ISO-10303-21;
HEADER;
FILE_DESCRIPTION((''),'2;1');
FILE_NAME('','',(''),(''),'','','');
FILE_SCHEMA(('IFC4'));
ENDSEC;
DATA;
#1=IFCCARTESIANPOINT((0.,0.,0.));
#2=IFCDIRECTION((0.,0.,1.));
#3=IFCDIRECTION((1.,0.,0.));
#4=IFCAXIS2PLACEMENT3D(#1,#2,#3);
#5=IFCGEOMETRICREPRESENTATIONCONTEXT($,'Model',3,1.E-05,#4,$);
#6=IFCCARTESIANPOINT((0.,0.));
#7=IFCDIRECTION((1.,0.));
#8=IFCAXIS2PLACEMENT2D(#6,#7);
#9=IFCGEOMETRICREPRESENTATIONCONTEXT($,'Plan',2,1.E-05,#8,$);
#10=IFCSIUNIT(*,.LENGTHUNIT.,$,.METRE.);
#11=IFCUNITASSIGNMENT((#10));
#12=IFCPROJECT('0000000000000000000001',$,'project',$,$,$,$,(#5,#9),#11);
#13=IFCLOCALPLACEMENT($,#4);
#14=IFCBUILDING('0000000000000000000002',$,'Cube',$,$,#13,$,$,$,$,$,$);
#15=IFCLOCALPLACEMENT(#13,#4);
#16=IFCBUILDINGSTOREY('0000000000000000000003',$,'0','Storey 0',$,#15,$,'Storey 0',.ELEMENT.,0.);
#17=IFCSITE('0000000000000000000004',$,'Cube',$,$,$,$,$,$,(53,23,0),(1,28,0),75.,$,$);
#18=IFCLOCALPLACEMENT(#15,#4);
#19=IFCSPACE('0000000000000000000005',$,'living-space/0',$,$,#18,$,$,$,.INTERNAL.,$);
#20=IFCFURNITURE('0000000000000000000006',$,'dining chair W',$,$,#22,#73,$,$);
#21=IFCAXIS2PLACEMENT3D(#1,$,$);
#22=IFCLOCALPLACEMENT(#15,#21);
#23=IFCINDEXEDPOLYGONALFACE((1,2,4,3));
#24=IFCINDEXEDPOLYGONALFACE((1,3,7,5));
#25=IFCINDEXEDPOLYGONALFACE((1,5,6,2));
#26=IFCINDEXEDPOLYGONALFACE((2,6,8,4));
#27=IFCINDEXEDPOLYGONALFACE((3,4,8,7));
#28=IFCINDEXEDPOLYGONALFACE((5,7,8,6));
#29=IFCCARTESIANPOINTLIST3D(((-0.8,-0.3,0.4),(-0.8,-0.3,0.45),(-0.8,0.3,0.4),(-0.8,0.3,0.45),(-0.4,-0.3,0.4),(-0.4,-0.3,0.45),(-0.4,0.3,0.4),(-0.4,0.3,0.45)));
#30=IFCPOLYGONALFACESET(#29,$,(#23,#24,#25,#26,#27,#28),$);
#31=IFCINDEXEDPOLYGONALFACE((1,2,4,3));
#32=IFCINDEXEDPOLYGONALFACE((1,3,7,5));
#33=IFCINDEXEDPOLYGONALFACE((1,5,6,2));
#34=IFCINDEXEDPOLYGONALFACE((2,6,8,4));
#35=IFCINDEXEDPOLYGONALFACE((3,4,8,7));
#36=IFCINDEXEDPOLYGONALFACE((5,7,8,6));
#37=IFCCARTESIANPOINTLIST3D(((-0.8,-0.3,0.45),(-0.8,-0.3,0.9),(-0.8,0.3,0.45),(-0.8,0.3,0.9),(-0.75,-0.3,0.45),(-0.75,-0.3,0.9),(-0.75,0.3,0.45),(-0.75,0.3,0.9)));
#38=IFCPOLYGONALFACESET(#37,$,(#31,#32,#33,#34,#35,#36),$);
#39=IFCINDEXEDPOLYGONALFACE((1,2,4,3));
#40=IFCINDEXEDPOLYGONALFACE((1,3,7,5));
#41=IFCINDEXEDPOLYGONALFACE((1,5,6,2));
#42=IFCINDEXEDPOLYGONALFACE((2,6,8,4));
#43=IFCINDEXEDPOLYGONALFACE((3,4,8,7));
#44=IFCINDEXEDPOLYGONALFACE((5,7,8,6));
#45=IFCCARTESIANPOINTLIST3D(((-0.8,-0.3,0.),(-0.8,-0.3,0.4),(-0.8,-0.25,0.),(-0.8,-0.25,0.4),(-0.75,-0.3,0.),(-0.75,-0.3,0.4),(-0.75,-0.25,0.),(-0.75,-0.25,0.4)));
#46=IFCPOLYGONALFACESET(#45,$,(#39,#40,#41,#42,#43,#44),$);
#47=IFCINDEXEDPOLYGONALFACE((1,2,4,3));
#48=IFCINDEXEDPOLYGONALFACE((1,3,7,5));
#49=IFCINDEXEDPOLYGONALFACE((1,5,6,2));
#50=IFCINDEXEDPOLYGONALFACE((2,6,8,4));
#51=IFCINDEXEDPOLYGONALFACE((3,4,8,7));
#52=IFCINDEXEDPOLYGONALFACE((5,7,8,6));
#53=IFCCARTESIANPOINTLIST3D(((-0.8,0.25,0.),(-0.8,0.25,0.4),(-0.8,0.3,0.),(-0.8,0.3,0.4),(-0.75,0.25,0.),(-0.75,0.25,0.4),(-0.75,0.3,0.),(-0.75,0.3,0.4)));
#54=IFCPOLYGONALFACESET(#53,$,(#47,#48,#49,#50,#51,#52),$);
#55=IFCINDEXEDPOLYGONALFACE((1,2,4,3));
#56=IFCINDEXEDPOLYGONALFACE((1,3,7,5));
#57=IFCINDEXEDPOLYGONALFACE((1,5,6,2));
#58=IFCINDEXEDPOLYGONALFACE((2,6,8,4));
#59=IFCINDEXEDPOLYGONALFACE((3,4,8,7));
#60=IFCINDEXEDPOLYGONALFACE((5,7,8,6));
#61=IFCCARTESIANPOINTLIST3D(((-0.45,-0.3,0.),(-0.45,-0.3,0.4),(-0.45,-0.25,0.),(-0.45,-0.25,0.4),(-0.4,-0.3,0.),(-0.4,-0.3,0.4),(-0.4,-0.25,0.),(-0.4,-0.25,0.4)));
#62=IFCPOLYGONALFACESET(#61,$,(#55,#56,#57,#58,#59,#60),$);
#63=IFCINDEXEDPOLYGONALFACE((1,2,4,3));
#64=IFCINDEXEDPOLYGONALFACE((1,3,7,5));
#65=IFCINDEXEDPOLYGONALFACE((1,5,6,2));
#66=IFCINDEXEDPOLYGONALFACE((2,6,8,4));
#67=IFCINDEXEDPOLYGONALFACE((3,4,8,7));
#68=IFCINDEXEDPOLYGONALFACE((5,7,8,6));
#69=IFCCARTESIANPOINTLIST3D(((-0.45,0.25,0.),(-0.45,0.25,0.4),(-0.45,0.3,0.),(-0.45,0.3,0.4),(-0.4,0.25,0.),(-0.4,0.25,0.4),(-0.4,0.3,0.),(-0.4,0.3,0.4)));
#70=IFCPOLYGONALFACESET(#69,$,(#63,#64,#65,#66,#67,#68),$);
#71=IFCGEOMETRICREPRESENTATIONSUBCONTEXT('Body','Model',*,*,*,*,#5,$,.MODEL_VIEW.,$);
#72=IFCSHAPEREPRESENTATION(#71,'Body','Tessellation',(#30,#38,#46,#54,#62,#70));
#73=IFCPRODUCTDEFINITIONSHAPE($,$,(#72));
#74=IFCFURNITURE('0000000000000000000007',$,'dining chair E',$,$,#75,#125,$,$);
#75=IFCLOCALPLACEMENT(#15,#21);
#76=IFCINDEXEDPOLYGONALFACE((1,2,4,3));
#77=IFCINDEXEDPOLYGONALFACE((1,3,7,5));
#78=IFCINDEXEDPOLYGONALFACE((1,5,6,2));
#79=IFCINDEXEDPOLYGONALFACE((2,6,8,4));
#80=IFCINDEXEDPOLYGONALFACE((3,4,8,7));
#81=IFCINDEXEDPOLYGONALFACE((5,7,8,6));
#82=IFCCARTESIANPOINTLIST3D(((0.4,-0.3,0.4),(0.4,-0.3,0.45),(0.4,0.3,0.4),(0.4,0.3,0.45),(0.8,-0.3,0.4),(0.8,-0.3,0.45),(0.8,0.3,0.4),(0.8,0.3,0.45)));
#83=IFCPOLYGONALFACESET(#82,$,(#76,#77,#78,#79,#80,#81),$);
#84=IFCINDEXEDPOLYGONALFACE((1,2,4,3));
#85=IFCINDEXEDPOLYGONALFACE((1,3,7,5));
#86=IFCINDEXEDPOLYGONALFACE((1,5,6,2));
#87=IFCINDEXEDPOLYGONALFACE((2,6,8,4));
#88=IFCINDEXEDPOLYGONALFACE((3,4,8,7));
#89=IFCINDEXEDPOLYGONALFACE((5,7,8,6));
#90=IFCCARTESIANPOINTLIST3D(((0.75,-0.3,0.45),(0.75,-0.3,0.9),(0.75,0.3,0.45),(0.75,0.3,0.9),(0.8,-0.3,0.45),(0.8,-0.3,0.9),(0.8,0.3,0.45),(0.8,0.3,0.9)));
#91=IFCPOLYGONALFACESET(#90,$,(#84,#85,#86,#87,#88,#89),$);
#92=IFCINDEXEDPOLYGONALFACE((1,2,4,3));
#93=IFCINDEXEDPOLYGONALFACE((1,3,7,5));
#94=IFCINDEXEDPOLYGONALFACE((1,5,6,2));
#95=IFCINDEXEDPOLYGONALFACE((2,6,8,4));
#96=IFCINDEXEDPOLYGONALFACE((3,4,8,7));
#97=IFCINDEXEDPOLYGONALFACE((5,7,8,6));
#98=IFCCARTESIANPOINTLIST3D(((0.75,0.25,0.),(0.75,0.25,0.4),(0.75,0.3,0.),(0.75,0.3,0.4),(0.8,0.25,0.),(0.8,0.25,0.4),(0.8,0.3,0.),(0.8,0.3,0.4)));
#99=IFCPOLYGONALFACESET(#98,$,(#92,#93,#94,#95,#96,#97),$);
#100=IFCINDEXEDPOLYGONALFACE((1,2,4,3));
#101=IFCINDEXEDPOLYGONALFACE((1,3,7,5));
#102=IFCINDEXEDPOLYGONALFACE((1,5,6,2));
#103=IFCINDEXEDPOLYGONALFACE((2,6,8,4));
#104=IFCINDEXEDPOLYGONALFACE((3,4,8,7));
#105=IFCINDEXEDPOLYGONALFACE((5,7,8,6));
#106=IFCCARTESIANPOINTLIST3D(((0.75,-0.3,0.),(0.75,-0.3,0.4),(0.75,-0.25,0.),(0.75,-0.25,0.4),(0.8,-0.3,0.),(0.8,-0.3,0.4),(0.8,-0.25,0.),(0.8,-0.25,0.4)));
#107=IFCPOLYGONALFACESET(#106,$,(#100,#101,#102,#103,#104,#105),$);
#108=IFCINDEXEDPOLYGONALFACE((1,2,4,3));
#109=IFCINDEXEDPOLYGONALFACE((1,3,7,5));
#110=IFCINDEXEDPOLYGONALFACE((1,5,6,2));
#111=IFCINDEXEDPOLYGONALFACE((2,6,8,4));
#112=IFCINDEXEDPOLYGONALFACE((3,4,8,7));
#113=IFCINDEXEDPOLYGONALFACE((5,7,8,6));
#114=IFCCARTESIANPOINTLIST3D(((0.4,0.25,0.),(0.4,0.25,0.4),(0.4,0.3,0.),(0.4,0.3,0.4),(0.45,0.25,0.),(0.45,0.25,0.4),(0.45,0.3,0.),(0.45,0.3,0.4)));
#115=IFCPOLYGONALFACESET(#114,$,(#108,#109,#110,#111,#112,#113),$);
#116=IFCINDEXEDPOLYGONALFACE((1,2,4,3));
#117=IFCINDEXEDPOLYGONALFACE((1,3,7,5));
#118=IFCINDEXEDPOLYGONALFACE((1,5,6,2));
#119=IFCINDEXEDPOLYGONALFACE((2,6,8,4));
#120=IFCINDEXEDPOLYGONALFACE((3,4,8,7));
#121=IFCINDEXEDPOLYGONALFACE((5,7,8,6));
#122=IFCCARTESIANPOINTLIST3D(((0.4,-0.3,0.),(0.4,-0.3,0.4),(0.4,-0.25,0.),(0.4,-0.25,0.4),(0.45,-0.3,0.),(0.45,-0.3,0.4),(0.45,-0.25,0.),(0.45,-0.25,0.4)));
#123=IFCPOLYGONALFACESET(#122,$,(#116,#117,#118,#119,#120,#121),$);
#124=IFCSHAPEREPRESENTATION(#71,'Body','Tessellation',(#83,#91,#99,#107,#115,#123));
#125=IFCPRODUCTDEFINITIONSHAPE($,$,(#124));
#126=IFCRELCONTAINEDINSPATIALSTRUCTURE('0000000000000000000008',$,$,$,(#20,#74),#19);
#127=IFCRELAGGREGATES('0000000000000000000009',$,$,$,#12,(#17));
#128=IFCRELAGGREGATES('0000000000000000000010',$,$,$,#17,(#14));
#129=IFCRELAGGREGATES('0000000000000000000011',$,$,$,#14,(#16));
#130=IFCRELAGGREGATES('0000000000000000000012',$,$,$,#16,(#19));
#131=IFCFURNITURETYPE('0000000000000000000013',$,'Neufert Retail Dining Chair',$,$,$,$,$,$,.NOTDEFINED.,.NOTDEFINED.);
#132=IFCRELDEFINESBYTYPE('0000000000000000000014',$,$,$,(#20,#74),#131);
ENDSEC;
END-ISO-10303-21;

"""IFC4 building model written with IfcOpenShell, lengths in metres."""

from ifc_helpers import new_model, entity, si_unit, frame, origin_with_axes, origin_2d_with_axis, place, context, subcontext, project, spatial, line, indexed_curve, outline, extrude, shape, source, transform, mapped, type_object, type_shapes, element, save


model = new_model("IFC4")

# Units and contexts
model_context = context("Model", 3, precision=1e-05, world=origin_with_axes())
plan_context = context("Plan", 2, precision=1e-05, world=origin_2d_with_axis())
body_context_1 = subcontext(model_context, "Body", "Model", "MODEL_VIEW")
body_context_2 = subcontext(plan_context, "Body", "Plan", "PLAN_VIEW")
ifc_project = project(units=[si_unit("LENGTHUNIT", "METRE")], contexts=[model_context, plan_context])

# Site, building, storey
site = spatial("IfcSite", under=ifc_project, Name="Cube", RefLatitude=(53, 23, 0), RefLongitude=(1, 28, 0), RefElevation=75.0)
building_placement = place(None, origin_with_axes())
building = spatial("IfcBuilding", under=site, at=building_placement, Name="Cube")
storey_placement = place(building_placement, origin_with_axes())
storey = spatial("IfcBuildingStorey", under=building, at=storey_placement, Name="0", Description="Storey 0", LongName="Storey 0", CompositionType="ELEMENT", Elevation=0.0)

# Shared definitions
space_placement = place(storey_placement, origin_with_axes())
space = spatial("IfcSpace", under=storey, at=space_placement, Name="living-space/0", PredefinedType="INTERNAL")

# Furniture
furniture_type_1 = type_object("IfcFurnitureType", Name="Neufert Retail Dining Chair", AssemblyPlace="NOTDEFINED", PredefinedType="NOTDEFINED")
shared_shape_1 = source(origin_with_axes(), body_context_1, "Body", "SweptSolid", [
    extrude(outline(indexed_curve([(-0.3, 0.0), (0.3, 0.0), (0.3, -0.4), (-0.3, -0.4)], segments=[line(1, 2, 3, 4, 1)])), frame((0.0, 0.0, 0.45), z_axis=(0.0, 0.0, 1.0), x_axis=(1.0, 0.0, 0.0)), (0.0, 0.0, -1.0), 0.05),
    extrude(outline(indexed_curve([(-0.3, 0.0), (0.3, 0.0), (0.3, -0.05), (-0.3, -0.05)], segments=[line(1, 2, 3, 4, 1)])), frame((0.0, 0.0, 0.9), z_axis=(0.0, 0.0, 1.0), x_axis=(1.0, 0.0, 0.0)), (0.0, 0.0, -1.0), 0.45),
    extrude(outline(indexed_curve([(-0.3, 0.0), (-0.25, 0.0), (-0.25, -0.05), (-0.3, -0.05)], segments=[line(1, 2, 3, 4, 1)])), origin_with_axes(), (0.0, 0.0, 1.0), 0.4),
    extrude(outline(indexed_curve([(0.3, 0.0), (0.25, 0.0), (0.25, -0.05), (0.3, -0.05)], segments=[line(1, 2, 3, 4, 1)])), origin_with_axes(), (0.0, 0.0, 1.0), 0.4),
    extrude(outline(indexed_curve([(-0.3, -0.4), (-0.25, -0.4), (-0.25, -0.35), (-0.3, -0.35)], segments=[line(1, 2, 3, 4, 1)])), origin_with_axes(), (0.0, 0.0, 1.0), 0.4),
    extrude(outline(indexed_curve([(0.3, -0.4), (0.25, -0.4), (0.25, -0.35), (0.3, -0.35)], segments=[line(1, 2, 3, 4, 1)])), origin_with_axes(), (0.0, 0.0, 1.0), 0.4),
])
shared_shape_2 = source(origin_with_axes(), body_context_2, "Body", "Curve2D", [
    entity("IfcIndexedPolyCurve", entity("IfcCartesianPointList2D", [[-0.3, -0.4], [0.3, -0.4]])),
    entity("IfcIndexedPolyCurve", entity("IfcCartesianPointList2D", [[-0.3, -0.4], [-0.3, -0.3], [-0.2121, -0.0879], [0.0, 0.0], [0.2121, -0.0879], [0.3, -0.3], [0.3, -0.4]]), [entity("IfcLineIndex", [1, 2]), entity("IfcArcIndex", [2, 3, 4]), entity("IfcArcIndex", [4, 5, 6]), entity("IfcLineIndex", [6, 7])]),
    entity("IfcIndexedPolyCurve", entity("IfcCartesianPointList2D", [[-0.26, -0.4], [-0.26, -0.3], [-0.1838, -0.1162], [0.0, -0.04], [0.1838, -0.1162], [0.26, -0.3], [0.26, -0.4]]), [entity("IfcLineIndex", [1, 2]), entity("IfcArcIndex", [2, 3, 4]), entity("IfcArcIndex", [4, 5, 6]), entity("IfcLineIndex", [6, 7])]),
])
type_shapes(furniture_type_1, [shared_shape_1, shared_shape_2])
for number, where, z_axis, x_axis, name in (
    (1, (-0.8, 0.0, 0.0), (0.0, 0.0, 1.0), (0.0, 1.0, 0.0), "dining chair W"),
    (2, (0.8, 0.0, 0.0), (0.0, 0.0, 1.0), (0.0, -1.0, 0.0), "dining chair E"),
):
    element("IfcFurniture", number, at=place(space_placement, frame(where, z_axis=z_axis, x_axis=x_axis)), inside=space, type_object=furniture_type_1, Name=name, shapes=[
        shape(body_context_1, "Body", "MappedRepresentation", [mapped(shared_shape_1, transform((0.0, 0.0, 0.0), x_axis=(1.0, 0.0, 0.0), y_axis=(0.0, 1.0, 0.0), z_axis=(0.0, 0.0, 1.0), scale=1.0))]),
        shape(body_context_2, "Body", "MappedRepresentation", [mapped(shared_shape_2, transform((0.0, 0.0, 0.0), x_axis=(1.0, 0.0, 0.0), y_axis=(0.0, 1.0, 0.0), z_axis=(0.0, 0.0, 1.0), scale=1.0))]),
    ])

save(model, "model.ifc")
